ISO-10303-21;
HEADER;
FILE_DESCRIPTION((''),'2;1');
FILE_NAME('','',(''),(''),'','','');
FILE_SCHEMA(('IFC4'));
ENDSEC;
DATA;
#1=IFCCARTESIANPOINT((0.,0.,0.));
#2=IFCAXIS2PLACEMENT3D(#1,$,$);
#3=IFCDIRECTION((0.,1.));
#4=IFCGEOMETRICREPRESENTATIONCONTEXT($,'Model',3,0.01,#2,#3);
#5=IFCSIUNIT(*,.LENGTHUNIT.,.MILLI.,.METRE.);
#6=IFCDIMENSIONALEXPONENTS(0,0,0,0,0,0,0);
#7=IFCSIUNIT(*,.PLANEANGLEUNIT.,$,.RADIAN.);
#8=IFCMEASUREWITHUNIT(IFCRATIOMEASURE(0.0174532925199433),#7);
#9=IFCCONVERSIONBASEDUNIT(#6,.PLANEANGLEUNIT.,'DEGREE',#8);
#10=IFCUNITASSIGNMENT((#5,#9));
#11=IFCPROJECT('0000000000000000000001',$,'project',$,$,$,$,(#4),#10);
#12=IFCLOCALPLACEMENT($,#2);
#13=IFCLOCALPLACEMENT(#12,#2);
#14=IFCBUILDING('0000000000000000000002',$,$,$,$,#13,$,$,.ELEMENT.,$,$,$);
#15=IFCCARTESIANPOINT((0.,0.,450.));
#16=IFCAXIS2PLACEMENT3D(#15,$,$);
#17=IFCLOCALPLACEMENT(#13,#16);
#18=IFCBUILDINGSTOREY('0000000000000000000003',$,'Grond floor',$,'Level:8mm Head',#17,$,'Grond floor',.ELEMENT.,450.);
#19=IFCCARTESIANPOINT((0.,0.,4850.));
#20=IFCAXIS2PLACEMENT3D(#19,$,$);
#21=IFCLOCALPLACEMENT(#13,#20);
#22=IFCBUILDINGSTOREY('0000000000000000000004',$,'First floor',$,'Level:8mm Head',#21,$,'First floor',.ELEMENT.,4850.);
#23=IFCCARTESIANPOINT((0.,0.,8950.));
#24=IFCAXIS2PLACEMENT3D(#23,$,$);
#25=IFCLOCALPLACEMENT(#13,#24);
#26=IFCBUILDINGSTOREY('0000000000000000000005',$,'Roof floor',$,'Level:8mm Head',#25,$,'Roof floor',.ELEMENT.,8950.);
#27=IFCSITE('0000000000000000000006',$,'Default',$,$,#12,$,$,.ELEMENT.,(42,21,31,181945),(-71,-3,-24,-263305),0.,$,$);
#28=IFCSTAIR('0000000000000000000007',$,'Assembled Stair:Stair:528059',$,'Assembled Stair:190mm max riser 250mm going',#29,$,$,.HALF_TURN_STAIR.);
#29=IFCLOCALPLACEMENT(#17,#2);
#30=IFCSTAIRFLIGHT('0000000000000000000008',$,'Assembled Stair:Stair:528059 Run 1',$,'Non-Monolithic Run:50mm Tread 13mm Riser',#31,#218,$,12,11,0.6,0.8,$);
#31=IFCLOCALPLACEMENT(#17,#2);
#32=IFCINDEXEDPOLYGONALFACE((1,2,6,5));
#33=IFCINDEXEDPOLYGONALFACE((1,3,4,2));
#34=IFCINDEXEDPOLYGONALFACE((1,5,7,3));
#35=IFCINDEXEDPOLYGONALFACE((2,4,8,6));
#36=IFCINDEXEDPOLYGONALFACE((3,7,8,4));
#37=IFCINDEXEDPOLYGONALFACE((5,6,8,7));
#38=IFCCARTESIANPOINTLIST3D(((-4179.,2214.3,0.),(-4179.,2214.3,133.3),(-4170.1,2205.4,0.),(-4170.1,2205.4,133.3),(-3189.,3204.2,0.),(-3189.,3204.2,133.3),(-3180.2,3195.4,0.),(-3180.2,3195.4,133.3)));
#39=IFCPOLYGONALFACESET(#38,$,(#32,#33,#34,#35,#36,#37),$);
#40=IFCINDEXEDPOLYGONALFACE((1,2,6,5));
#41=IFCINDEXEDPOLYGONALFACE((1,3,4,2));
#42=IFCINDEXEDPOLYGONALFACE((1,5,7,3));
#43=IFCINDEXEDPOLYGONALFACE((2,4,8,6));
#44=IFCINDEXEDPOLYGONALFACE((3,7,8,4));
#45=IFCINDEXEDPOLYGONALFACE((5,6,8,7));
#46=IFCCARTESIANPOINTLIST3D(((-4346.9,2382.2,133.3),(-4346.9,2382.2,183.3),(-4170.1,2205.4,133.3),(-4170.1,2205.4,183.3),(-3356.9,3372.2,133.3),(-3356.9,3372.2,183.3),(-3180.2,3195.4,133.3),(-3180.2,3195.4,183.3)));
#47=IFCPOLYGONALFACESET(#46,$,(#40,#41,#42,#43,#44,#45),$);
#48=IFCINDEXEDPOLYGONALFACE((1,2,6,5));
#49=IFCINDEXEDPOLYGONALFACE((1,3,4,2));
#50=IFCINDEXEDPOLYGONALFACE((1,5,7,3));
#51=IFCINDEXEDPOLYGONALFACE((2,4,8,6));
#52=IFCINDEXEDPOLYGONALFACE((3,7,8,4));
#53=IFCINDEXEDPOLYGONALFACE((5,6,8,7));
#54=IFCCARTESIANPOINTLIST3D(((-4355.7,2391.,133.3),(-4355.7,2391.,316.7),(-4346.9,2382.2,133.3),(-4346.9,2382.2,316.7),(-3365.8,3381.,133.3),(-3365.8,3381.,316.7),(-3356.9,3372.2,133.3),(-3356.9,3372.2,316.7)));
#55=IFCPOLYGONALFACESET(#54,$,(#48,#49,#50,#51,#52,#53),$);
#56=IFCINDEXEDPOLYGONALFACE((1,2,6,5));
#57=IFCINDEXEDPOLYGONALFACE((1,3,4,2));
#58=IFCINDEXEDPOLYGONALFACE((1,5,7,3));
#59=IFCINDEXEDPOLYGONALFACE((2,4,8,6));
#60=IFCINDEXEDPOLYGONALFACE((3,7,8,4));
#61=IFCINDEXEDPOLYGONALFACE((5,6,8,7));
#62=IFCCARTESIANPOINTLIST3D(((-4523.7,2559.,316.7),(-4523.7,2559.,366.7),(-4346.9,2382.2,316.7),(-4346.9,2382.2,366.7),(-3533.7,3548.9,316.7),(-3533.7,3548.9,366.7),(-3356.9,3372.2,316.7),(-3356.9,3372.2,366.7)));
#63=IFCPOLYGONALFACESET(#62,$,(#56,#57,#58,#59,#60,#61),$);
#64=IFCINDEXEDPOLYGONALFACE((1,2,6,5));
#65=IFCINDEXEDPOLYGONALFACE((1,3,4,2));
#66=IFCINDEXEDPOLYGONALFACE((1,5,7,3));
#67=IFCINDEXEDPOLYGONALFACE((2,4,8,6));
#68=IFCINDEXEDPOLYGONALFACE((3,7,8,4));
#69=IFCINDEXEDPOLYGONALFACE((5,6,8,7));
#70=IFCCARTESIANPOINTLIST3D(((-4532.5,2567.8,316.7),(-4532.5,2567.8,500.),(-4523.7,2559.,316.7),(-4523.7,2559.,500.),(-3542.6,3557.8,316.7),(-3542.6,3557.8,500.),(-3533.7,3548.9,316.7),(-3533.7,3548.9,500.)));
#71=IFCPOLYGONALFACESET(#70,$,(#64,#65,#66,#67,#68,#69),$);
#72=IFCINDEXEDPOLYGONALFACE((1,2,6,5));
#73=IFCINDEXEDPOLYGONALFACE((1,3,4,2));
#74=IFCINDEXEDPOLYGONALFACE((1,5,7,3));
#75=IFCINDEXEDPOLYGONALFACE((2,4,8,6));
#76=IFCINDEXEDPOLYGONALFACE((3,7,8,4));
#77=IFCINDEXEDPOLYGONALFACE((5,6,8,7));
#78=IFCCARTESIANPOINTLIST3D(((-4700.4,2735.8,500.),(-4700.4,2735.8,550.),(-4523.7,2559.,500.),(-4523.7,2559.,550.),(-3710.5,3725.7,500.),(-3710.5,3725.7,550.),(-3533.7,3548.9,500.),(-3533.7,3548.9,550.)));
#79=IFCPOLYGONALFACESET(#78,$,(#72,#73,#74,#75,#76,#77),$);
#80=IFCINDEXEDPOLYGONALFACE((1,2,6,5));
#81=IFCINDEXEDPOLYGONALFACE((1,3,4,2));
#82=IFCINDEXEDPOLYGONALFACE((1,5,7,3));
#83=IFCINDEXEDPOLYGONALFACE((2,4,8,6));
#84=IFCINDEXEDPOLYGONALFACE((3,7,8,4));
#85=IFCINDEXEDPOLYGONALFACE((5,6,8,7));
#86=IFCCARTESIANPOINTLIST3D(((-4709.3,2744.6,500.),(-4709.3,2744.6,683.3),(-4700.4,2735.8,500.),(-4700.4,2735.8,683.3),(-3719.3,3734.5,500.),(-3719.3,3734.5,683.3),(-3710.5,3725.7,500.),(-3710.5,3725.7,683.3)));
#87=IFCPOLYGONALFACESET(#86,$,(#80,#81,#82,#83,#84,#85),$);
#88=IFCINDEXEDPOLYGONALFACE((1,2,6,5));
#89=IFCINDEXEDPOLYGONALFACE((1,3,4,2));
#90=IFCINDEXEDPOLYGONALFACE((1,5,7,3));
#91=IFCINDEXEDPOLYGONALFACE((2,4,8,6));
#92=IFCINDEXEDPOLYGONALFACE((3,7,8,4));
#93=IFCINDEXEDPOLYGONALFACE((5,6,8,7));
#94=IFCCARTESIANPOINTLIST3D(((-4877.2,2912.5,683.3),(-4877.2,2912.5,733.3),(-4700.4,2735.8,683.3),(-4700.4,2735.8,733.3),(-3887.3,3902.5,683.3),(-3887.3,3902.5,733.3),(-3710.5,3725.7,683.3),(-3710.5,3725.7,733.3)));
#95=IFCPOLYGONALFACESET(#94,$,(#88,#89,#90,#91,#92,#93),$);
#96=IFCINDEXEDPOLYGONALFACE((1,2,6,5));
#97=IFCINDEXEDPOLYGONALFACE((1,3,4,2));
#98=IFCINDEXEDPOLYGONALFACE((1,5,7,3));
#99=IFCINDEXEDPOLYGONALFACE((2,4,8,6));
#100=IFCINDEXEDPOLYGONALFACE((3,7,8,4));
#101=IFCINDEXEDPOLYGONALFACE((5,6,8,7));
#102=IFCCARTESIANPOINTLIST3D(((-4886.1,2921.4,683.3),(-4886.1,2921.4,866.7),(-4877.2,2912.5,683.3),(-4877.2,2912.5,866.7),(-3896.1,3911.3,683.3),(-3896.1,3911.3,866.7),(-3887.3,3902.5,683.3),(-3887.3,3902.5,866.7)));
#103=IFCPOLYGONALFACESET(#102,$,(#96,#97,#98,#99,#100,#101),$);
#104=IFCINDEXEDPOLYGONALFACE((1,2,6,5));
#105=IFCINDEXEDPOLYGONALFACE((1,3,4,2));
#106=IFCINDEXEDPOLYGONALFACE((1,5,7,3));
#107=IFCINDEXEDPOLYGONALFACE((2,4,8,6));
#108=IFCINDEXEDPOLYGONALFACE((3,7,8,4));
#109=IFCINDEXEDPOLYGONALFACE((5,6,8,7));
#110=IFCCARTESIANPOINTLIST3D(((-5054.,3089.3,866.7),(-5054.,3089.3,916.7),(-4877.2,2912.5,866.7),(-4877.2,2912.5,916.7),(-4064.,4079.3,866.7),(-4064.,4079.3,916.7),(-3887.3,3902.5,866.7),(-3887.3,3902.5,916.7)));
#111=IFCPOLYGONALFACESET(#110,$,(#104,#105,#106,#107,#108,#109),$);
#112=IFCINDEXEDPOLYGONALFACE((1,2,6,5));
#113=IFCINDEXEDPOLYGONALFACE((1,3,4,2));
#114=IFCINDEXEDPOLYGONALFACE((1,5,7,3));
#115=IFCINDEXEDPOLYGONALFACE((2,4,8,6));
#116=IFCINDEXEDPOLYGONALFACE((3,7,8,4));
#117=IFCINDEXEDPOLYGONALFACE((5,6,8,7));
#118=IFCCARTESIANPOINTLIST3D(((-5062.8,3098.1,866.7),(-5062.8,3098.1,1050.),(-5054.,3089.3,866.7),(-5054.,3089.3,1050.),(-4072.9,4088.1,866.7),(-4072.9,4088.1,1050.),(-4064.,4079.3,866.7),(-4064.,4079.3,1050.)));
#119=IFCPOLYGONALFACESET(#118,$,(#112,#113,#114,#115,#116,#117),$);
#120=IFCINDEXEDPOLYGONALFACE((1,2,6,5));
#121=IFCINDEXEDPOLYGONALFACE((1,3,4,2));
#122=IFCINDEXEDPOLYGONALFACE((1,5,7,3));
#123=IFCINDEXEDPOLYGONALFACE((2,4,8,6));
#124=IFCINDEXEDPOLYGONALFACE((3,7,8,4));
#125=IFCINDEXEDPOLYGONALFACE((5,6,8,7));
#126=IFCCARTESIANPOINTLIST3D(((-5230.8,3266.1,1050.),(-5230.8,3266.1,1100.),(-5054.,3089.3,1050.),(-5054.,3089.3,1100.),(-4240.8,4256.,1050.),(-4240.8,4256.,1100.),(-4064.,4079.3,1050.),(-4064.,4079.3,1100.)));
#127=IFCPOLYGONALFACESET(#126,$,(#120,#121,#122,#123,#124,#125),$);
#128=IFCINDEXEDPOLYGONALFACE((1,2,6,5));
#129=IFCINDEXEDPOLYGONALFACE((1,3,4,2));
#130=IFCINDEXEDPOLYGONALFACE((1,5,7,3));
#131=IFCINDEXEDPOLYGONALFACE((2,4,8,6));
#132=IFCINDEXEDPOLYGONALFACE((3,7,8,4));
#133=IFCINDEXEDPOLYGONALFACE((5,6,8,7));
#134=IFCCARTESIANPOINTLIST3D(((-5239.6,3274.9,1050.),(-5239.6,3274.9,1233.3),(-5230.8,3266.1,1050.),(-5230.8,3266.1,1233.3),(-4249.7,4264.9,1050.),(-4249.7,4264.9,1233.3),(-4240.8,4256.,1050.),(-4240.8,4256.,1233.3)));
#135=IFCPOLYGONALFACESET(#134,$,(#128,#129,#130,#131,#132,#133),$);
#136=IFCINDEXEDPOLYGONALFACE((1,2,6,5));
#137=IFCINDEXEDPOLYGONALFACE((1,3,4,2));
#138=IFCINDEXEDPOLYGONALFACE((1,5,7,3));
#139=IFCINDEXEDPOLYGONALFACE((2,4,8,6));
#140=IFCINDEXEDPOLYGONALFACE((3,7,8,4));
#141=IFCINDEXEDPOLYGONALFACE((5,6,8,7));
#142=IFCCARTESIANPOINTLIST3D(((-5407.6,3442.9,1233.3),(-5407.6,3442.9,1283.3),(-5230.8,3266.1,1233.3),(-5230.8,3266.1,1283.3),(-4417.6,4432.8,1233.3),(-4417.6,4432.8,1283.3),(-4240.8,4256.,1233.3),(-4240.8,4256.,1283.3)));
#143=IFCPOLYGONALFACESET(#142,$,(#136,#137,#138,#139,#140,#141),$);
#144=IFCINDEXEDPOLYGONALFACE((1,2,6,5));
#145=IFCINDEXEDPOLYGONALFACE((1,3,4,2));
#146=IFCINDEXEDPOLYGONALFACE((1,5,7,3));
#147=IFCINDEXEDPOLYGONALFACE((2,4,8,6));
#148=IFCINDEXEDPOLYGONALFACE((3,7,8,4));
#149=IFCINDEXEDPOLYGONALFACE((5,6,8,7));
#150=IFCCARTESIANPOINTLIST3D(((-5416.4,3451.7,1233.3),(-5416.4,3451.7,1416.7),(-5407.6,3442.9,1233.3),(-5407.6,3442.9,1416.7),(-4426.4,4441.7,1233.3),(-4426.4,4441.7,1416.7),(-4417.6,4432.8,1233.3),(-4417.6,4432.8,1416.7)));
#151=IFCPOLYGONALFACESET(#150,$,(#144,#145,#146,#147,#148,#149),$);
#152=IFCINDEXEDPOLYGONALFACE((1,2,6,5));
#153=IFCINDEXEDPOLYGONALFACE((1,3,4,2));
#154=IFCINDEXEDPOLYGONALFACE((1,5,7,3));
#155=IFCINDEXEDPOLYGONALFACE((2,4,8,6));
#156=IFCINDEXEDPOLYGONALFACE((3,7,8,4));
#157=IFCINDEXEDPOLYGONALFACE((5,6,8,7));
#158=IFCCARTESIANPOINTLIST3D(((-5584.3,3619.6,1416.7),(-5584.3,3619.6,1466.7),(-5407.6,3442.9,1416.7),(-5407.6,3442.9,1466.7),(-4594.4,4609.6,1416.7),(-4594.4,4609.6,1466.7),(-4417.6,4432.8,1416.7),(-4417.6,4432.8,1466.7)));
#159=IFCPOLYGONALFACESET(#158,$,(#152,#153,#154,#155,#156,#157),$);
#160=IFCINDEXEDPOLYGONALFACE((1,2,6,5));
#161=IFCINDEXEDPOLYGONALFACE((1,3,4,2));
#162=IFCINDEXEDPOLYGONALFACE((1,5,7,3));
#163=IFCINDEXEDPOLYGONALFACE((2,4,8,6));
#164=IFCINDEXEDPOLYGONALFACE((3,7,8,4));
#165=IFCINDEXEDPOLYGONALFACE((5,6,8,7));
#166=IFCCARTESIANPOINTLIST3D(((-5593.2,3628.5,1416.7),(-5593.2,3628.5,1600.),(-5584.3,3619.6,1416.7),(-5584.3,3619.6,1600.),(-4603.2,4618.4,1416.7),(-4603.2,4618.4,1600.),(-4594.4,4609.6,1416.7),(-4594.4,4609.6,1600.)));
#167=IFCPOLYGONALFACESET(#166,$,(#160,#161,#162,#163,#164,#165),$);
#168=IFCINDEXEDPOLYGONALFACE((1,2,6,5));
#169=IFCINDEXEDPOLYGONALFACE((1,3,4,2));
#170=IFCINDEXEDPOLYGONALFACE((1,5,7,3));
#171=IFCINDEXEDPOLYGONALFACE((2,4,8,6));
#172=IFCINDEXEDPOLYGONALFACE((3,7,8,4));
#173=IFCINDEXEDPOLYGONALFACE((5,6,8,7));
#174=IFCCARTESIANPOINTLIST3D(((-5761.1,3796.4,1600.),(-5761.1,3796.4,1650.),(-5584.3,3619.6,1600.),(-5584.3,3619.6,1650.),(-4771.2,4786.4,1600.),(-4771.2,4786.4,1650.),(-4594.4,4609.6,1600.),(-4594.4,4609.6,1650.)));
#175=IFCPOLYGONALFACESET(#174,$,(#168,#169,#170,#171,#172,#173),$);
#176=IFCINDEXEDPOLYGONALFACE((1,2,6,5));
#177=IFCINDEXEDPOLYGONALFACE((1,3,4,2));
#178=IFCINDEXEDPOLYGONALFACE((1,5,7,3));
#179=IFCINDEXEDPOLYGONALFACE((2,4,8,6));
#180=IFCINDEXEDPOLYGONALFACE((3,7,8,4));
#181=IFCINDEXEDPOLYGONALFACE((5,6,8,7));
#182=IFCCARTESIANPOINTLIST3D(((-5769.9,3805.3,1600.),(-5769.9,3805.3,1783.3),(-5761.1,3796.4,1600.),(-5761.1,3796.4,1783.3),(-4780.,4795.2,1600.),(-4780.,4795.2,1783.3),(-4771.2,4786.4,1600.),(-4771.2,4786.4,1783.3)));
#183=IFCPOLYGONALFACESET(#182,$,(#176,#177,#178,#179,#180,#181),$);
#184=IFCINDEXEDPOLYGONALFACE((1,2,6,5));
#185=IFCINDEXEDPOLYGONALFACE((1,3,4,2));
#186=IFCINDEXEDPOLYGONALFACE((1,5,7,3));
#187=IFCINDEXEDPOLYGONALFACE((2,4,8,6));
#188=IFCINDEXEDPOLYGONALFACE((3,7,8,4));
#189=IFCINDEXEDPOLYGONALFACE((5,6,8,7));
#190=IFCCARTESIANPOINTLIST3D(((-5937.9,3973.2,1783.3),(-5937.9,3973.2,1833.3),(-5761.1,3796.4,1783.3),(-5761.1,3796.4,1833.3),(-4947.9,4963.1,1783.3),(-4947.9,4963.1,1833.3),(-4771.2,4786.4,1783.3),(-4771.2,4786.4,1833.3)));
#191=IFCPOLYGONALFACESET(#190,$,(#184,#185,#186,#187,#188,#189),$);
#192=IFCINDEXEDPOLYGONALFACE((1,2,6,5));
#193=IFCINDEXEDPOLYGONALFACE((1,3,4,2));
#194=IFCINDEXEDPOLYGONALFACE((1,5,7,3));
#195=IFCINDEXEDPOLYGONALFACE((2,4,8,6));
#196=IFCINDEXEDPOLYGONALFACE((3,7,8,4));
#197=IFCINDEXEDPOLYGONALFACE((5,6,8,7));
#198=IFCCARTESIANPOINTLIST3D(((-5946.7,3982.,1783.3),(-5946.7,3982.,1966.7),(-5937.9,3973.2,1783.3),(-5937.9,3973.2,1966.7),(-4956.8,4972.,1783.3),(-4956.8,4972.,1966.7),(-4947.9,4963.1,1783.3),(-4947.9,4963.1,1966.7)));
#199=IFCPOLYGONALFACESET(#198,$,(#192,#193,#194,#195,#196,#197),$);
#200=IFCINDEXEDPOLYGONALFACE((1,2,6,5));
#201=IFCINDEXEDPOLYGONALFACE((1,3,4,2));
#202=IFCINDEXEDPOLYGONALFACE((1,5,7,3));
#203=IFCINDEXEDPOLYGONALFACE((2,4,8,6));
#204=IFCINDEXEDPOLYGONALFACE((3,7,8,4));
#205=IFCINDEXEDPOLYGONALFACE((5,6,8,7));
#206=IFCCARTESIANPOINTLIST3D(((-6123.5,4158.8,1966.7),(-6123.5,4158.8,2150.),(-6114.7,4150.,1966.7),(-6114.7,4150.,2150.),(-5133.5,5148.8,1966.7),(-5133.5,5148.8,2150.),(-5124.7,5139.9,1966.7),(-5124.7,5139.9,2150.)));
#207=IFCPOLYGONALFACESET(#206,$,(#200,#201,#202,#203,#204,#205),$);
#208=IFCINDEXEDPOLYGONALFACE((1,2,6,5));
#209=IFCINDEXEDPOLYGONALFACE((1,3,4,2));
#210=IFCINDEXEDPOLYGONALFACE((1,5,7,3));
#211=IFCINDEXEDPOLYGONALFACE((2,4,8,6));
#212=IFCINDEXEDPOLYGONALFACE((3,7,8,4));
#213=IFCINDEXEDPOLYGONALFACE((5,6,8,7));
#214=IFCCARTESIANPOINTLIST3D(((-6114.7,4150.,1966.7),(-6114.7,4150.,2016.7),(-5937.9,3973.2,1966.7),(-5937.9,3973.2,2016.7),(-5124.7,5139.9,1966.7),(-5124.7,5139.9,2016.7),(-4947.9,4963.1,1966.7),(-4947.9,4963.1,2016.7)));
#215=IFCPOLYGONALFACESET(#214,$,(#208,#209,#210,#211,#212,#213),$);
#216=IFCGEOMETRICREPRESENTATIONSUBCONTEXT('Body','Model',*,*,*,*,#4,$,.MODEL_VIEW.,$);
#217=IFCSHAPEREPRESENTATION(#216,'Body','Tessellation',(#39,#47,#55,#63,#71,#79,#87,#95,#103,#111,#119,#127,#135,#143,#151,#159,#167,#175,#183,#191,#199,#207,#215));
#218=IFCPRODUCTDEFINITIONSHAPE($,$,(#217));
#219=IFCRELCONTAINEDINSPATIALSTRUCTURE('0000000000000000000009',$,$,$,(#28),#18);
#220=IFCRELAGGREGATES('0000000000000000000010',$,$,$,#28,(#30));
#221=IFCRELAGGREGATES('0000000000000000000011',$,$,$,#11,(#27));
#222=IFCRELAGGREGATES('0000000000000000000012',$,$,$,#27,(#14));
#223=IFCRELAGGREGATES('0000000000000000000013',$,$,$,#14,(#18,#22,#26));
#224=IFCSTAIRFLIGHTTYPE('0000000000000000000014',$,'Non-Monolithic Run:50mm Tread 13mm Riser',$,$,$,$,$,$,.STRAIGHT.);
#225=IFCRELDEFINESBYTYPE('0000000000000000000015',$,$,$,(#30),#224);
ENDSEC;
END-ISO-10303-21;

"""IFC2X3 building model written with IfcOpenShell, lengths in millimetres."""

from ifc_helpers import new_model, entity, si_unit, converted_unit, direction, frame, frame_2d, origin, origin_2d_with_axis, place, context, subcontext, project, spatial, rectangle, extrude, type_object, element, aggregate, save


model = new_model("IFC2X3")

# Units and contexts
model_context = context("Model", 3, precision=0.01, world=origin(), true_north=direction((0.0, 1.0)))
body_context = subcontext(model_context, "Body", "Model", "MODEL_VIEW")
ifc_project = project(units=[si_unit("LENGTHUNIT", "METRE", prefix="MILLI"), converted_unit("PLANEANGLEUNIT", "DEGREE", entity("IfcRatioMeasure", 0.0174532925199433), si_unit("PLANEANGLEUNIT", "RADIAN"), dimensions=[0, 0, 0, 0, 0, 0, 0])], contexts=[model_context])

# Site, building, storey
site_placement = place(None, origin())
site = spatial("IfcSite", under=ifc_project, at=site_placement, Name="Default", CompositionType="ELEMENT", RefLatitude=(42, 21, 31, 181945), RefLongitude=(-71, -3, -24, -263305), RefElevation=0.0)
building_placement = place(site_placement, origin())
building = spatial("IfcBuilding", under=site, at=building_placement, CompositionType="ELEMENT")
storey_1_placement = place(building_placement, frame((0.0, 0.0, 450.0)))
storey_1 = spatial("IfcBuildingStorey", under=building, at=storey_1_placement, Name="Grond floor", ObjectType="Level:8mm Head", LongName="Grond floor", CompositionType="ELEMENT", Elevation=450.0)

# Stair
stair_1_placement = place(storey_1_placement, origin())
stair_1 = element("IfcStair", 1, at=stair_1_placement, inside=storey_1, Name="Assembled Stair:Stair:528059", ObjectType="Assembled Stair:190mm max riser 250mm going", ShapeType="HALF_TURN_STAIR")

# Shared definitions
storey_2_placement = place(building_placement, frame((0.0, 0.0, 4850.0)))
storey_2 = spatial("IfcBuildingStorey", under=building, at=storey_2_placement, Name="First floor", ObjectType="Level:8mm Head", LongName="First floor", CompositionType="ELEMENT", Elevation=4850.0)

# Shared definitions
storey_3_placement = place(building_placement, frame((0.0, 0.0, 8950.0)))
storey_3 = spatial("IfcBuildingStorey", under=building, at=storey_3_placement, Name="Roof floor", ObjectType="Level:8mm Head", LongName="Roof floor", CompositionType="ELEMENT", Elevation=8950.0)

# Stair flight
stair_flight_type_1 = type_object("IfcStairFlightType", Name="Non-Monolithic Run:50mm Tread 13mm Riser", PredefinedType="STRAIGHT")
stair_flight_1_placement = place(stair_1_placement, origin())
stair_flight_1 = element("IfcStairFlight", 2, at=stair_flight_1_placement, type_object=stair_flight_type_1, Name="Assembled Stair:Stair:528059 Run 1", ObjectType="Non-Monolithic Run:50mm Tread 13mm Riser", NumberOfRiser=12, NumberOfTreads=11, RiserHeight=0.6, TreadLength=0.8, context=body_context, shape_type="SweptSolid", body=[
    extrude(rectangle(XDim=1400.0, YDim=12.5, at=frame_2d((0.0, 0.0), x_axis=(1.0, 0.0))), frame((-3679.6, 2704.8, 0.0), z_axis=(0.0, 0.0, 1.0), x_axis=(-0.707107, -0.707107, 0.0)), (0.0, 0.0, 1.0), 133.3),
    extrude(rectangle(XDim=250.0, YDim=1400.0, at=frame_2d((0.0, 0.0), x_axis=(1.0, 0.0))), frame((-3763.5, 2788.8, 133.3), z_axis=(0.0, 0.0, 1.0), x_axis=(0.707107, -0.707107, 0.0)), (0.0, 0.0, 1.0), 50.0),
    extrude(rectangle(XDim=1400.0, YDim=12.5, at=frame_2d((0.0, 0.0), x_axis=(1.0, 0.0))), frame((-3856.3, 2881.6, 133.3), z_axis=(0.0, 0.0, 1.0), x_axis=(-0.707107, -0.707107, 0.0)), (0.0, 0.0, 1.0), 183.3),
    extrude(rectangle(XDim=250.0, YDim=1400.0, at=origin_2d_with_axis()), frame((-3940.3, 2965.6, 316.7), z_axis=(0.0, 0.0, 1.0), x_axis=(0.707107, -0.707107, 0.0)), (0.0, 0.0, 1.0), 50.0),
    extrude(rectangle(XDim=1400.0, YDim=12.5, at=origin_2d_with_axis()), frame((-4033.1, 3058.4, 316.7), z_axis=(0.0, 0.0, 1.0), x_axis=(-0.707107, -0.707107, 0.0)), (0.0, 0.0, 1.0), 183.3),
    extrude(rectangle(XDim=250.0, YDim=1400.0, at=origin_2d_with_axis()), frame((-4117.1, 3142.3, 500.0), z_axis=(0.0, 0.0, 1.0), x_axis=(0.707107, -0.707107, 0.0)), (0.0, 0.0, 1.0), 50.0),
    extrude(rectangle(XDim=1400.0, YDim=12.5, at=origin_2d_with_axis()), frame((-4209.9, 3235.2, 500.0), z_axis=(0.0, 0.0, 1.0), x_axis=(-0.707107, -0.707107, 0.0)), (0.0, 0.0, 1.0), 183.3),
    extrude(rectangle(XDim=250.0, YDim=1400.0, at=frame_2d((0.0, 0.0), x_axis=(1.0, 0.0))), frame((-4293.9, 3319.1, 683.3), z_axis=(0.0, 0.0, 1.0), x_axis=(0.707107, -0.707107, 0.0)), (0.0, 0.0, 1.0), 50.0),
    extrude(rectangle(XDim=1400.0, YDim=12.5, at=origin_2d_with_axis()), frame((-4386.7, 3411.9, 683.3), z_axis=(0.0, 0.0, 1.0), x_axis=(-0.707107, -0.707107, 0.0)), (0.0, 0.0, 1.0), 183.3),
    extrude(rectangle(XDim=250.0, YDim=1400.0, at=frame_2d((0.0, 0.0), x_axis=(1.0, 0.0))), frame((-4470.6, 3495.9, 866.7), z_axis=(0.0, 0.0, 1.0), x_axis=(0.707107, -0.707107, 0.0)), (0.0, 0.0, 1.0), 50.0),
    extrude(rectangle(XDim=1400.0, YDim=12.5, at=frame_2d((0.0, 0.0), x_axis=(1.0, 0.0))), frame((-4563.4, 3588.7, 866.7), z_axis=(0.0, 0.0, 1.0), x_axis=(-0.707107, -0.707107, 0.0)), (0.0, 0.0, 1.0), 183.3),
    extrude(rectangle(XDim=250.0, YDim=1400.0, at=frame_2d((0.0, 0.0), x_axis=(1.0, 0.0))), frame((-4647.4, 3672.7, 1050.0), z_axis=(0.0, 0.0, 1.0), x_axis=(0.707107, -0.707107, 0.0)), (0.0, 0.0, 1.0), 50.0),
    extrude(rectangle(XDim=1400.0, YDim=12.5, at=origin_2d_with_axis()), frame((-4740.2, 3765.5, 1050.0), z_axis=(0.0, 0.0, 1.0), x_axis=(-0.707107, -0.707107, 0.0)), (0.0, 0.0, 1.0), 183.3),
    extrude(rectangle(XDim=250.0, YDim=1400.0, at=frame_2d((0.0, 0.0), x_axis=(1.0, 0.0))), frame((-4824.2, 3849.4, 1233.3), z_axis=(0.0, 0.0, 1.0), x_axis=(0.707107, -0.707107, 0.0)), (0.0, 0.0, 1.0), 50.0),
    extrude(rectangle(XDim=1400.0, YDim=12.5, at=frame_2d((0.0, 0.0), x_axis=(1.0, 0.0))), frame((-4917.0, 3942.3, 1233.3), z_axis=(0.0, 0.0, 1.0), x_axis=(-0.707107, -0.707107, 0.0)), (0.0, 0.0, 1.0), 183.3),
    extrude(rectangle(XDim=250.0, YDim=1400.0, at=frame_2d((0.0, 0.0), x_axis=(1.0, 0.0))), frame((-5001.0, 4026.2, 1416.7), z_axis=(0.0, 0.0, 1.0), x_axis=(0.707107, -0.707107, 0.0)), (0.0, 0.0, 1.0), 50.0),
    extrude(rectangle(XDim=1400.0, YDim=12.5, at=frame_2d((0.0, 0.0), x_axis=(1.0, 0.0))), frame((-5093.8, 4119.0, 1416.7), z_axis=(0.0, 0.0, 1.0), x_axis=(-0.707107, -0.707107, 0.0)), (0.0, 0.0, 1.0), 183.3),
    extrude(rectangle(XDim=250.0, YDim=1400.0, at=frame_2d((0.0, 0.0), x_axis=(1.0, 0.0))), frame((-5177.7, 4203.0, 1600.0), z_axis=(0.0, 0.0, 1.0), x_axis=(0.707107, -0.707107, 0.0)), (0.0, 0.0, 1.0), 50.0),
    extrude(rectangle(XDim=1400.0, YDim=12.5, at=frame_2d((0.0, 0.0), x_axis=(1.0, 0.0))), frame((-5270.5, 4295.8, 1600.0), z_axis=(0.0, 0.0, 1.0), x_axis=(-0.707107, -0.707107, 0.0)), (0.0, 0.0, 1.0), 183.3),
    extrude(rectangle(XDim=250.0, YDim=1400.0, at=frame_2d((0.0, 0.0), x_axis=(1.0, 0.0))), frame((-5354.5, 4379.8, 1783.3), z_axis=(0.0, 0.0, 1.0), x_axis=(0.707107, -0.707107, 0.0)), (0.0, 0.0, 1.0), 50.0),
    extrude(rectangle(XDim=1400.0, YDim=12.5, at=frame_2d((0.0, 0.0), x_axis=(1.0, 0.0))), frame((-5447.3, 4472.6, 1783.3), z_axis=(0.0, 0.0, 1.0), x_axis=(-0.707107, -0.707107, 0.0)), (0.0, 0.0, 1.0), 183.3),
    extrude(rectangle(XDim=1400.0, YDim=12.5, at=frame_2d((0.0, 0.0), x_axis=(1.0, 0.0))), frame((-5624.1, 4649.4, 1966.7), z_axis=(0.0, 0.0, 1.0), x_axis=(-0.707107, -0.707107, 0.0)), (0.0, 0.0, 1.0), 183.3),
    extrude(rectangle(XDim=250.0, YDim=1400.0, at=frame_2d((0.0, 0.0), x_axis=(1.0, 0.0))), frame((-5531.3, 4556.6, 1966.7), z_axis=(0.0, 0.0, 1.0), x_axis=(0.707107, -0.707107, 0.0)), (0.0, 0.0, 1.0), 50.0),
])
aggregate(stair_1, [stair_flight_1])

save(model, "model.ifc")
